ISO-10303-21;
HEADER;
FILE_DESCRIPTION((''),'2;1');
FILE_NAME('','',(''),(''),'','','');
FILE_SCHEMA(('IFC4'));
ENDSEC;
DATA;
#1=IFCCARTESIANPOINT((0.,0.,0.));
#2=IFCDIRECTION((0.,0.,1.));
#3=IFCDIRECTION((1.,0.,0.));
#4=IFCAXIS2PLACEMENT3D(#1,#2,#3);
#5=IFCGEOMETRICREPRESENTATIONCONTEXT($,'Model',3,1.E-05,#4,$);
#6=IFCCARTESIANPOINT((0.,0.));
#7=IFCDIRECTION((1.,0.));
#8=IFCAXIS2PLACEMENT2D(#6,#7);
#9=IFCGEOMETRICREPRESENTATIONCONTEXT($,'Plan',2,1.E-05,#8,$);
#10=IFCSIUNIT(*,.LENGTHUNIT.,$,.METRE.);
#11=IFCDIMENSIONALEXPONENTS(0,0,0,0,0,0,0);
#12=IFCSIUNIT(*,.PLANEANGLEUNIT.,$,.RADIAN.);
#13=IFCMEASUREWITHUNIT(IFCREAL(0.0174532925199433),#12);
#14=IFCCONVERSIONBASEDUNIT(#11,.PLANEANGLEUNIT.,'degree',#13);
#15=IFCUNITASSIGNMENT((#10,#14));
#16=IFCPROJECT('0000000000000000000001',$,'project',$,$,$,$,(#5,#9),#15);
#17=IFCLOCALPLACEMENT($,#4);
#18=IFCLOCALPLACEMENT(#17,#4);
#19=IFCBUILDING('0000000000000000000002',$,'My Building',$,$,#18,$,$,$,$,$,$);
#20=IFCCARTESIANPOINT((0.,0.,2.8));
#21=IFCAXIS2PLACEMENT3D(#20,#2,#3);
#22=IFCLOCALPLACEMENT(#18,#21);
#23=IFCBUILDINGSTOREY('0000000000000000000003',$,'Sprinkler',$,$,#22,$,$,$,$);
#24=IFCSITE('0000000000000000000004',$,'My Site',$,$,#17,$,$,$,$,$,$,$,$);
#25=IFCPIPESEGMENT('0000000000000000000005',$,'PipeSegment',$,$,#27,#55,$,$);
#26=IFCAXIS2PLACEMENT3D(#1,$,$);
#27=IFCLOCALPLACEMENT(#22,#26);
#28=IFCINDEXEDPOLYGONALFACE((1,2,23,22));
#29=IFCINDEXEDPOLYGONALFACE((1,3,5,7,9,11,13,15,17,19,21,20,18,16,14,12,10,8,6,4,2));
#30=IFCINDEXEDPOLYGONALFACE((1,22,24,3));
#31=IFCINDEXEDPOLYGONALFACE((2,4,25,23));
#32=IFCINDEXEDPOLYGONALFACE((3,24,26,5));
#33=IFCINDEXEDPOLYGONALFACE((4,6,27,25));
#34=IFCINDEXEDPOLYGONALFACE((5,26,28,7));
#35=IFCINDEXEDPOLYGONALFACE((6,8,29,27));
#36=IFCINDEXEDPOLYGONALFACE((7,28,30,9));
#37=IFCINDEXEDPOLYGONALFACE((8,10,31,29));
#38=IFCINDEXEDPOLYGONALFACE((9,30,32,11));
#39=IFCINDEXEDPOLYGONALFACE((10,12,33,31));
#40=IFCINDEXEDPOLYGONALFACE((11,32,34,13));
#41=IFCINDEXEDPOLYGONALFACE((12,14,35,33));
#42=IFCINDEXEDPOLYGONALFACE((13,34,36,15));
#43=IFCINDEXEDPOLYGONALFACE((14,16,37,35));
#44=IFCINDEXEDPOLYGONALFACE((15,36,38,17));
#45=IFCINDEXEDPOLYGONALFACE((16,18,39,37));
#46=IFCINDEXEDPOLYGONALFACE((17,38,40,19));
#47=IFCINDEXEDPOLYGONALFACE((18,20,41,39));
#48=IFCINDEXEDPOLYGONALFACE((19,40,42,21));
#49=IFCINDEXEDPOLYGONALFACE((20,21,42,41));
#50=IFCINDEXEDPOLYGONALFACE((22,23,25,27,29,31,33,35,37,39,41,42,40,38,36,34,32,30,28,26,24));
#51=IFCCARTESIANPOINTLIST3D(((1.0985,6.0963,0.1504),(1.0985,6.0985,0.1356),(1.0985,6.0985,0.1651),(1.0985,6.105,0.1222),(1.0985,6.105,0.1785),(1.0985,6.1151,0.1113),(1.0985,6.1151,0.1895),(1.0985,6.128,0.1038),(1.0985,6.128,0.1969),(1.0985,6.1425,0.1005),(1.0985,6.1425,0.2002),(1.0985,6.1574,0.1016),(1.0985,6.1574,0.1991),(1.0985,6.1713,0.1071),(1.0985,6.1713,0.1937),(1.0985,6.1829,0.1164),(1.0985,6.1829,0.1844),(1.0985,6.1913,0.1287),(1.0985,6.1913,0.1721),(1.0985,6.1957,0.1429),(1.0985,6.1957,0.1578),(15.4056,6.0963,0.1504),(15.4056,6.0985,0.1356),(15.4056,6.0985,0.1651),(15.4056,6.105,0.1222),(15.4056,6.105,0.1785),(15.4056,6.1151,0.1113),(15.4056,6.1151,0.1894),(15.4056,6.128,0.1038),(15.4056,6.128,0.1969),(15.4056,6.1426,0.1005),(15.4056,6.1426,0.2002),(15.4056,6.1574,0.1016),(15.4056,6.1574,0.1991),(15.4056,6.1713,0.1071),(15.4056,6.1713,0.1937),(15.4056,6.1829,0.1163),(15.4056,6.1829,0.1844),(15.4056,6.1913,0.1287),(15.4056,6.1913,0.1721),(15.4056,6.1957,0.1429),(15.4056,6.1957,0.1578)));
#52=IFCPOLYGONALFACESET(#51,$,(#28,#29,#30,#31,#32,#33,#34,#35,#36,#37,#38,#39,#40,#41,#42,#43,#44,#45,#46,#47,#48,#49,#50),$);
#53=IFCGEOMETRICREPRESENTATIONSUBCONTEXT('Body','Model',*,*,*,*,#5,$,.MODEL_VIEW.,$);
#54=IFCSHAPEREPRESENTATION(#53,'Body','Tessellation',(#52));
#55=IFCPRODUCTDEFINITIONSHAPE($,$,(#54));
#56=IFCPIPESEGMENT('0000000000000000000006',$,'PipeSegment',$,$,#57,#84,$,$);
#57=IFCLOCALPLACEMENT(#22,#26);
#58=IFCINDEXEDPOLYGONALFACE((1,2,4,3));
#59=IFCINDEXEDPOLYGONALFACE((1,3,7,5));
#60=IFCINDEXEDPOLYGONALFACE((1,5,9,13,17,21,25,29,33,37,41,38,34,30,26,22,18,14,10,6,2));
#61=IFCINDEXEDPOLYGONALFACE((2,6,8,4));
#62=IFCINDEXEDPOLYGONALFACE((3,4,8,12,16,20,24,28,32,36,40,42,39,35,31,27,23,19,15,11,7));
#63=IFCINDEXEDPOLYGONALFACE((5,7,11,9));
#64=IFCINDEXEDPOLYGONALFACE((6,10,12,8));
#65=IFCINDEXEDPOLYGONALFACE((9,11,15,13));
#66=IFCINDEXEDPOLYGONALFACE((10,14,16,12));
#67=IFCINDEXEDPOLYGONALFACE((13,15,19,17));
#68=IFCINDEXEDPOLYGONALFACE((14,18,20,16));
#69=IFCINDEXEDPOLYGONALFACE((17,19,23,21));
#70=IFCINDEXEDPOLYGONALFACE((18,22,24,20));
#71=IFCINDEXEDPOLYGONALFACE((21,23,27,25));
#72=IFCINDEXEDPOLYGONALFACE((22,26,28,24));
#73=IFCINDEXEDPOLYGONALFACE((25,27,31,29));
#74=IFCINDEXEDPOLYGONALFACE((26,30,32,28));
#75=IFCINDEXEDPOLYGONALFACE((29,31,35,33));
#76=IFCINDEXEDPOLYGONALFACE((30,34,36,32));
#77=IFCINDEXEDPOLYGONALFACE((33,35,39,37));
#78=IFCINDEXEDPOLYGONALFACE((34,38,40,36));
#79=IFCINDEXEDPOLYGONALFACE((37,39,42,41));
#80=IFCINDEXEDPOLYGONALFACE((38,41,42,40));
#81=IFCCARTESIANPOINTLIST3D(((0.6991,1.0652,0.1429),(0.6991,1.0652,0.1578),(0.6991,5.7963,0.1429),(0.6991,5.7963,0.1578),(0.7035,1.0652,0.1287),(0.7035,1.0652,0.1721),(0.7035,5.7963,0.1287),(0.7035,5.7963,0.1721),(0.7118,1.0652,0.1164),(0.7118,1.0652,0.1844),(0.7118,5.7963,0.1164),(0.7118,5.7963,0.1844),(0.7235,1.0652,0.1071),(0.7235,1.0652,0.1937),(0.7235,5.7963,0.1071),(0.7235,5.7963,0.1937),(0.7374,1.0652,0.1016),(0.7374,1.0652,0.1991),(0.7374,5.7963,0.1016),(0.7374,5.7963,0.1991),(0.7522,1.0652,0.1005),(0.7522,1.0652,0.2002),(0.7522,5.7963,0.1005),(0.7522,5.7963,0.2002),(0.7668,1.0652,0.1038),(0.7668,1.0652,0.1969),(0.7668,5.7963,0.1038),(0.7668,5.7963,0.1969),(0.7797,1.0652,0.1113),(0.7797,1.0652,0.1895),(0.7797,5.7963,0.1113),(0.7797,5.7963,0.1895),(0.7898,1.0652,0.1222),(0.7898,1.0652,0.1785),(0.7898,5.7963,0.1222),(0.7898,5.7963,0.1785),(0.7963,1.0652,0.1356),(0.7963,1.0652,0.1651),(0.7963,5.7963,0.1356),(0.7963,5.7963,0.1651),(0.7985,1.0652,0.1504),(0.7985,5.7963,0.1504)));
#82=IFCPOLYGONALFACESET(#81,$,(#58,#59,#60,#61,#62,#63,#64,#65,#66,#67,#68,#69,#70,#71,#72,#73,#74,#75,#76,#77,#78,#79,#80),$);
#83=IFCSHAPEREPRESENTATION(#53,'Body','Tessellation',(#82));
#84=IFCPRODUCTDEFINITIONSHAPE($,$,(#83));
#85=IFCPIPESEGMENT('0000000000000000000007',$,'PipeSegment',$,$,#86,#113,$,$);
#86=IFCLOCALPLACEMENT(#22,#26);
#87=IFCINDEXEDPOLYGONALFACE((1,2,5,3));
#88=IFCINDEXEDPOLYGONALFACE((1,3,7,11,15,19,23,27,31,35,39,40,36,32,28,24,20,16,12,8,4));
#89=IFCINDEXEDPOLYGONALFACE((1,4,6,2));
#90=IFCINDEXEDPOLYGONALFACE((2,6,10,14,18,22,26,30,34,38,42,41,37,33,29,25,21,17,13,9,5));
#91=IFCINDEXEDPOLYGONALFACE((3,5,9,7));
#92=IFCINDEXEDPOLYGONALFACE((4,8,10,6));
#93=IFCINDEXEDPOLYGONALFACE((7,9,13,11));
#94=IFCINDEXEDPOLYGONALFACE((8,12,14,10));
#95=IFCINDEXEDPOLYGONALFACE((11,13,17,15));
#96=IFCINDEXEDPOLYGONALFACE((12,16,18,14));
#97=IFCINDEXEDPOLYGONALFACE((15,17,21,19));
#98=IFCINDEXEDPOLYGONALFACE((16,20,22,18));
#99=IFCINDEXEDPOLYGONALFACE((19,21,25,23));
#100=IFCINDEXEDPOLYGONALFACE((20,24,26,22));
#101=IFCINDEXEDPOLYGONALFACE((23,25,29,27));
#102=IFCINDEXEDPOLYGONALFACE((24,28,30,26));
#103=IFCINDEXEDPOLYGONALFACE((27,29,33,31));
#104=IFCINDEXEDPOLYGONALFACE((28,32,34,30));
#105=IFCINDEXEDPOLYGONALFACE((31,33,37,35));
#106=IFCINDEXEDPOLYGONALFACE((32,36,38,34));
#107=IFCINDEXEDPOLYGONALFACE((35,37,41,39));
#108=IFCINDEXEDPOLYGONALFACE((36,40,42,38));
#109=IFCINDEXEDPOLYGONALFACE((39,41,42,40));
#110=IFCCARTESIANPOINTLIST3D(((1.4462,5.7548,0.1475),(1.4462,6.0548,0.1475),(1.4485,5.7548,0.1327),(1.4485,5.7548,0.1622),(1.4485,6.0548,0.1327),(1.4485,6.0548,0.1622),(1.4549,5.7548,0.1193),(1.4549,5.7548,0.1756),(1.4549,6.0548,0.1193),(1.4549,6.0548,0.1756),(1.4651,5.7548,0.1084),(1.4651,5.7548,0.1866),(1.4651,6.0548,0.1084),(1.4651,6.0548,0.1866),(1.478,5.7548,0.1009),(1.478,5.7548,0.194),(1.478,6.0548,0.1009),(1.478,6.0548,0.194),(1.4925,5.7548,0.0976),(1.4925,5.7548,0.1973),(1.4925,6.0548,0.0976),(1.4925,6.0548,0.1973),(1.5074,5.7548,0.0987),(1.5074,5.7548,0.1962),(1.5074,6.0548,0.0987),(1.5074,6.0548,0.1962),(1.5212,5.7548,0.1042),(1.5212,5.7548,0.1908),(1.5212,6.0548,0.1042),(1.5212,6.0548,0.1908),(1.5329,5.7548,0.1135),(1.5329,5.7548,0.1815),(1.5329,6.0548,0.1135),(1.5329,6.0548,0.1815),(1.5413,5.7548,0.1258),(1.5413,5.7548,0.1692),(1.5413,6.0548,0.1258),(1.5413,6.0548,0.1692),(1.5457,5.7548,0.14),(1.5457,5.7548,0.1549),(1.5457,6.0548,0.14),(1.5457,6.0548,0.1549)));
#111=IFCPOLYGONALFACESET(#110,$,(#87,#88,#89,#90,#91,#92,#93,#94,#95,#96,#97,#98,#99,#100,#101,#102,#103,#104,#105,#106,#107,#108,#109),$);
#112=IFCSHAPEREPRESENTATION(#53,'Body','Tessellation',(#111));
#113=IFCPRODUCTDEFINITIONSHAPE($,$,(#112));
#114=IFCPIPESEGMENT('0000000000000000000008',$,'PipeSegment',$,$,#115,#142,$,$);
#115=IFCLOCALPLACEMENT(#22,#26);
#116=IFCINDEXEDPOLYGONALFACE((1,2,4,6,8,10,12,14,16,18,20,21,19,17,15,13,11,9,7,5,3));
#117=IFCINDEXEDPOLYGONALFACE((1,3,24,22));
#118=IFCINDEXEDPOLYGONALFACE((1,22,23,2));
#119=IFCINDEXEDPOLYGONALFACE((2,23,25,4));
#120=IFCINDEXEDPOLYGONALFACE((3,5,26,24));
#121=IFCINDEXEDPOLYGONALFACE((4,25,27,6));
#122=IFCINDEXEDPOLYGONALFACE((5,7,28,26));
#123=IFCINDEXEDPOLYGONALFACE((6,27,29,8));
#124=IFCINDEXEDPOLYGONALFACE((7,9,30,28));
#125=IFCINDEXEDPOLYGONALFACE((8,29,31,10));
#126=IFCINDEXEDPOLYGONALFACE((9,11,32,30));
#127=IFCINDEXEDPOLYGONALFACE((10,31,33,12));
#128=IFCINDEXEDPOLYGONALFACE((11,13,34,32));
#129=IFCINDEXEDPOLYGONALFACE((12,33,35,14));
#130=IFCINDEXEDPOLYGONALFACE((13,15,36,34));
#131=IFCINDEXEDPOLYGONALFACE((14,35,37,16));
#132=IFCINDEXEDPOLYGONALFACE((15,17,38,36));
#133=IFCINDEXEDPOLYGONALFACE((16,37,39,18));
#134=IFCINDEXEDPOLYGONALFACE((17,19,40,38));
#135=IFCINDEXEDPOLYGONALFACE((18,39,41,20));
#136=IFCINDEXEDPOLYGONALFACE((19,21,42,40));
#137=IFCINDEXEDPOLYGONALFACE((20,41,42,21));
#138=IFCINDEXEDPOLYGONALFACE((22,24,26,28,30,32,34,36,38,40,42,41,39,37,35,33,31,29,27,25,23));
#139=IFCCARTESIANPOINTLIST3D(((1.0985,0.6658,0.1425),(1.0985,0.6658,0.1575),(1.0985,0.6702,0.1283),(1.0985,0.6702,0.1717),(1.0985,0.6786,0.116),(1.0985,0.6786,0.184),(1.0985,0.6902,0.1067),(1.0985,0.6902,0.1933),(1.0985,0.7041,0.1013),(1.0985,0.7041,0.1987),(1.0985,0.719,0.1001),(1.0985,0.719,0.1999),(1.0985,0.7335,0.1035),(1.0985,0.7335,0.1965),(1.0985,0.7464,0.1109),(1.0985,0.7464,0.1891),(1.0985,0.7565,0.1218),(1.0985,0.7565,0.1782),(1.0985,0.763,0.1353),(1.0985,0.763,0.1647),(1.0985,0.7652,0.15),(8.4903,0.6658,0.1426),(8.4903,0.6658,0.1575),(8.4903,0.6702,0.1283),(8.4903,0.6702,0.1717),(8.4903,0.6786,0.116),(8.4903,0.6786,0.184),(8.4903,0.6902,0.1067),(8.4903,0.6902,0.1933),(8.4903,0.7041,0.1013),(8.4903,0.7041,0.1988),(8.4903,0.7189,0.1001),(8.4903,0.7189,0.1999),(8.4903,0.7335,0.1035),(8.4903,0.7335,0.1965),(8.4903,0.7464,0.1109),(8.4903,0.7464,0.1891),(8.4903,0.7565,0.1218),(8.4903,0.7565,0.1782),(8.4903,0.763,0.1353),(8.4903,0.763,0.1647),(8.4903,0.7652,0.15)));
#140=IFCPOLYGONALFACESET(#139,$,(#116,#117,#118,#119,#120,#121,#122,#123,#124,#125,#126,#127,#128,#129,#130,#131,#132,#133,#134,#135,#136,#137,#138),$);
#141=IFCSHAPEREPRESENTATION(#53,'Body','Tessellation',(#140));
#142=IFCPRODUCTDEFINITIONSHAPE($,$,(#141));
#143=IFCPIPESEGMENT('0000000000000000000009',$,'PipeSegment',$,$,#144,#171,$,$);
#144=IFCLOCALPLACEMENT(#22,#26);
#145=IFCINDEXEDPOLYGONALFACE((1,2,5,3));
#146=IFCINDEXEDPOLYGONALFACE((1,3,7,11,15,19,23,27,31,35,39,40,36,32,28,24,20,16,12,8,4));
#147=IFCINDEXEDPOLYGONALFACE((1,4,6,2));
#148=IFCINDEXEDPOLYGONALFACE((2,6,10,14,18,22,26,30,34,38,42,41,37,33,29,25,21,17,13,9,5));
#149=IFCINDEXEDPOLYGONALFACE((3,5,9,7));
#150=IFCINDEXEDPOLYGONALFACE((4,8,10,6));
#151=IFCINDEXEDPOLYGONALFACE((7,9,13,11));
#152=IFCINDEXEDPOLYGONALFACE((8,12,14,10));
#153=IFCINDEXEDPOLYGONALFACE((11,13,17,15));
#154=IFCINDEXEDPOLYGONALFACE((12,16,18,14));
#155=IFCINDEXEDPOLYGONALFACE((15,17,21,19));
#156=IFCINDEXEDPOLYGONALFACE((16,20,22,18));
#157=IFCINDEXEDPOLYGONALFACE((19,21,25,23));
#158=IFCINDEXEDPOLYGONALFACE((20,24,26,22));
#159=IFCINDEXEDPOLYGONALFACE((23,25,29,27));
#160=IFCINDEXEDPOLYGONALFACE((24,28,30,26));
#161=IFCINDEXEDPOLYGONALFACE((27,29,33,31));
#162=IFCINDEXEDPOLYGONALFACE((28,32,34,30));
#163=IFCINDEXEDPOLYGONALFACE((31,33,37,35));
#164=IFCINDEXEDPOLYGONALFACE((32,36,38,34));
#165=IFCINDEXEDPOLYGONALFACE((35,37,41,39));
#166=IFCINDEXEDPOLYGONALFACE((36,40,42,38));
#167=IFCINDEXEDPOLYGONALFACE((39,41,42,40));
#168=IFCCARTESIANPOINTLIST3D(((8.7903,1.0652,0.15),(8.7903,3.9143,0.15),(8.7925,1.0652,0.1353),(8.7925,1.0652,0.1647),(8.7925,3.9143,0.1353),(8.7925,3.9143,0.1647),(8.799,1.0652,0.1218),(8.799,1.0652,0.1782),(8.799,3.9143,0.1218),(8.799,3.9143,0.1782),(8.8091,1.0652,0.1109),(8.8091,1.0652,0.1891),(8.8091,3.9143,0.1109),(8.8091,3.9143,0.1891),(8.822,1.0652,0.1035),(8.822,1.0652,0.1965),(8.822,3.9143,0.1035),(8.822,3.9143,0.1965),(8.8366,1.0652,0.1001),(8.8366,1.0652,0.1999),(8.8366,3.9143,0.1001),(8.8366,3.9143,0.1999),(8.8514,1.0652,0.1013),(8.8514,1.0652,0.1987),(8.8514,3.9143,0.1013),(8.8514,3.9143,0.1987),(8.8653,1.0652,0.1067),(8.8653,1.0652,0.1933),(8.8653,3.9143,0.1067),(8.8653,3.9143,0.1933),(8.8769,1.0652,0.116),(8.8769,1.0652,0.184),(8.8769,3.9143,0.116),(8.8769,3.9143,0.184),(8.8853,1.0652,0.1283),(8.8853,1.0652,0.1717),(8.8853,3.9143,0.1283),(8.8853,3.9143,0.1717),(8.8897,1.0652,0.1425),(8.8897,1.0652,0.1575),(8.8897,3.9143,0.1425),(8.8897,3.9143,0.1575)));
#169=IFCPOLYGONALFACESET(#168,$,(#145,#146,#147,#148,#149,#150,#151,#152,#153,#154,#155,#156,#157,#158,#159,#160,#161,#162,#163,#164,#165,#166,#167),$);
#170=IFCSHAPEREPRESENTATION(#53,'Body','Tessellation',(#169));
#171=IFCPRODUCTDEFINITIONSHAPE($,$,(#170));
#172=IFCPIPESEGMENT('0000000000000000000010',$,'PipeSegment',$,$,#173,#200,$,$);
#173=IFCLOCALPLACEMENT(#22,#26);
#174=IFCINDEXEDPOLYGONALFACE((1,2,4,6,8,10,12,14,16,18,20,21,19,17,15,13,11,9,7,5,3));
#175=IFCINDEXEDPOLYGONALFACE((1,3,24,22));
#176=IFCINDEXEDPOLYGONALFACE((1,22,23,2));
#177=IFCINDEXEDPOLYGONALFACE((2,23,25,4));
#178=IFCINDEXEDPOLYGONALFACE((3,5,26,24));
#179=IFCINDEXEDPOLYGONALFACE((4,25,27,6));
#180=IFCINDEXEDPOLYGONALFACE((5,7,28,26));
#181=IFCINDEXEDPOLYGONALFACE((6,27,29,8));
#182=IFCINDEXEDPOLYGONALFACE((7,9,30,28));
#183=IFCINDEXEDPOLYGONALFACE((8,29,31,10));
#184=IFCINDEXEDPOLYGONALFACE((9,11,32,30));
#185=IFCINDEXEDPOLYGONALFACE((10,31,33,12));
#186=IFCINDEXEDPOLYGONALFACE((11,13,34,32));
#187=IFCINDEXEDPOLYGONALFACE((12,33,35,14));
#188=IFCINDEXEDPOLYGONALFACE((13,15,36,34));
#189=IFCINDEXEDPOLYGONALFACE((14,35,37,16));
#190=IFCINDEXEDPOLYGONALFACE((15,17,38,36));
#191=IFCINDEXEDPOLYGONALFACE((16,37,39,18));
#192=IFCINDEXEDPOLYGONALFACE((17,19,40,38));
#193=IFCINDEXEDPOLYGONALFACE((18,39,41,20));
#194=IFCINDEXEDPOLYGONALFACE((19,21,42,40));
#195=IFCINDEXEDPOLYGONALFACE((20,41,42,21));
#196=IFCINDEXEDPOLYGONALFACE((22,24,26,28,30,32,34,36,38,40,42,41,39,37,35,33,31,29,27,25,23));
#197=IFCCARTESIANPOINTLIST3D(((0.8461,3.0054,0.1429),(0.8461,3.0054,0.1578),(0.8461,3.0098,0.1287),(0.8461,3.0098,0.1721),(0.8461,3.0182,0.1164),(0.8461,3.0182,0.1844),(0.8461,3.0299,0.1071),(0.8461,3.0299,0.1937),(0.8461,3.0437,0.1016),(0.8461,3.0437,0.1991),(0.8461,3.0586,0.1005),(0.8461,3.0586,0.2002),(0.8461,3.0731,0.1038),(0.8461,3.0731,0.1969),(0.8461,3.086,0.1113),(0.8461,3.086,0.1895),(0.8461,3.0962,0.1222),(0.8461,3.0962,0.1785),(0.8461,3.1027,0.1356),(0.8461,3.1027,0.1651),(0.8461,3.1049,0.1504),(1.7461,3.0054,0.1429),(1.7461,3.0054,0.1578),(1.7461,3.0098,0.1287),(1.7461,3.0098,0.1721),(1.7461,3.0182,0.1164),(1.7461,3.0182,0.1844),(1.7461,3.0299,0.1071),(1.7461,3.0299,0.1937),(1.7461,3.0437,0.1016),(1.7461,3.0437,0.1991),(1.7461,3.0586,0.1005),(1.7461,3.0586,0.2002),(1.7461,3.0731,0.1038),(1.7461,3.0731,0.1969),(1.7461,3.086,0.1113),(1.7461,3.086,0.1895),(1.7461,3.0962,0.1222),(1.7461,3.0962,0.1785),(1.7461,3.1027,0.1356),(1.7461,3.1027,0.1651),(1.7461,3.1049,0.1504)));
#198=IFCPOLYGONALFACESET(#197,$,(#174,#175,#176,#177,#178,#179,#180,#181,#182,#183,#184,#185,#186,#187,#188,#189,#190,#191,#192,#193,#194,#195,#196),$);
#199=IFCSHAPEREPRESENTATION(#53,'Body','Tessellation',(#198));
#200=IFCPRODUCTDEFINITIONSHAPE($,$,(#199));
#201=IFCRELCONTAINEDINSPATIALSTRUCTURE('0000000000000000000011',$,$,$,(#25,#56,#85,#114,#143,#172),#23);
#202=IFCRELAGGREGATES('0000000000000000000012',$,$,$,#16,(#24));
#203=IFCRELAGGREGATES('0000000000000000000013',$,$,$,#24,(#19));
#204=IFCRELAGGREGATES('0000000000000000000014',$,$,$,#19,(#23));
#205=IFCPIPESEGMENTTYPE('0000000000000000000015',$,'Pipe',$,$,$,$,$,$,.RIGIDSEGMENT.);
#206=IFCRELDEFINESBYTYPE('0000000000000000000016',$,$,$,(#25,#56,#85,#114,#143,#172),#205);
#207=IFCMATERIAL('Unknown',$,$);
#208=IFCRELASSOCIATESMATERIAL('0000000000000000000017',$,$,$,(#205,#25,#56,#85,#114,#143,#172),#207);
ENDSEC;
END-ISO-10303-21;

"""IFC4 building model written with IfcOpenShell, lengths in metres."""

from ifc_helpers import new_model, entity, si_unit, converted_unit, frame, origin_with_axes, origin_2d_with_axis, place, context, subcontext, project, spatial, circle, extrude, material, material_profile, profile_set, profile_usage, type_object, element, save


model = new_model("IFC4")

# Units and contexts
model_context = context("Model", 3, precision=1e-05, world=origin_with_axes())
plan_context = context("Plan", 2, precision=1e-05, world=origin_2d_with_axis())
body_context = subcontext(model_context, "Body", "Model", "MODEL_VIEW")
ifc_project = project(units=[si_unit("LENGTHUNIT", "METRE"), converted_unit("PLANEANGLEUNIT", "degree", entity("IfcReal", 0.0174532925199433), si_unit("PLANEANGLEUNIT", "RADIAN"), dimensions=[0, 0, 0, 0, 0, 0, 0])], contexts=[model_context, plan_context])

# Site, building, storey
site_placement = place(None, origin_with_axes())
site = spatial("IfcSite", under=ifc_project, at=site_placement, Name="My Site")
building_placement = place(site_placement, origin_with_axes())
building = spatial("IfcBuilding", under=site, at=building_placement, Name="My Building")
storey_placement = place(building_placement, frame((0.0, 0.0, 2.8), z_axis=(0.0, 0.0, 1.0), x_axis=(1.0, 0.0, 0.0)))
storey = spatial("IfcBuildingStorey", under=building, at=storey_placement, Name="Sprinkler")

# Pipe segments
ifc_material = material(Name="Unknown")
ifc_material_profile_1 = material_profile(ifc_material, circle(Radius=0.05))
ifc_profile_set_1 = profile_set([ifc_material_profile_1])
ifc_profile_usage_1 = profile_usage(ifc_profile_set_1, cardinal=5)
pipe_segment_type = type_object("IfcPipeSegmentType", Name="Pipe", PredefinedType="RIGIDSEGMENT", material=ifc_profile_set_1)
pipe_segment_1_placement = place(storey_placement, frame((15.4056, 6.1463, 0.1504), z_axis=(-1.0, -0.000001, 0.0), x_axis=(0.000001, -1.0, 0.0)))
element("IfcPipeSegment", 1, at=pipe_segment_1_placement, inside=storey, type_object=pipe_segment_type, material=ifc_profile_usage_1, Name="PipeSegment", context=body_context, shape_type="SweptSolid", body=[
    extrude(circle(Radius=0.05), origin_with_axes(), (0.0, 0.0, 1.0), 14.3071),
])
ifc_profile_usage_2 = profile_usage(ifc_profile_set_1, cardinal=5)
pipe_segment_2_placement = place(storey_placement, frame((0.7485, 5.7963, 0.1504), z_axis=(0.0, -1.0, 0.0), x_axis=(1.0, 0.0, 0.0)))
element("IfcPipeSegment", 2, at=pipe_segment_2_placement, inside=storey, type_object=pipe_segment_type, material=ifc_profile_usage_2, Name="PipeSegment", context=body_context, shape_type="SweptSolid", body=[
    extrude(circle(Radius=0.05), origin_with_axes(), (0.0, 0.0, 1.0), 4.7311),
])
ifc_profile_usage_3 = profile_usage(ifc_profile_set_1, cardinal=5)
pipe_segment_3_placement = place(storey_placement, frame((1.4962, 5.7548, 0.1475), z_axis=(0.0, 1.0, -0.000008), x_axis=(-1.0, 0.0, 0.0)))
element("IfcPipeSegment", 3, at=pipe_segment_3_placement, inside=storey, type_object=pipe_segment_type, material=ifc_profile_usage_3, Name="PipeSegment", context=body_context, shape_type="SweptSolid", body=[
    extrude(circle(Radius=0.05), origin_with_axes(), (0.0, 0.0, 1.0), 0.3),
])
ifc_profile_usage_4 = profile_usage(ifc_profile_set_1, cardinal=8)
pipe_segment_4_placement = place(storey_placement, frame((1.0985, 0.7152, 0.2), z_axis=(1.0, -0.000001, 0.000001), x_axis=(0.000001, 1.0, 0.0)))
element("IfcPipeSegment", 4, at=pipe_segment_4_placement, inside=storey, type_object=pipe_segment_type, material=ifc_profile_usage_4, Name="PipeSegment", context=body_context, shape_type="SweptSolid", body=[
    extrude(circle(Radius=0.05), frame((0.0, -0.05, 0.0), z_axis=(0.0, 0.0, 1.0), x_axis=(1.0, 0.0, 0.0)), (0.0, 0.0, 1.0), 7.3918),
])
ifc_profile_usage_5 = profile_usage(ifc_profile_set_1, cardinal=8)
pipe_segment_5_placement = place(storey_placement, frame((8.8403, 1.0652, 0.2), z_axis=(0.0, 1.0, 0.0), x_axis=(-1.0, 0.0, 0.0)))
element("IfcPipeSegment", 5, at=pipe_segment_5_placement, inside=storey, type_object=pipe_segment_type, material=ifc_profile_usage_5, Name="PipeSegment", context=body_context, shape_type="SweptSolid", body=[
    extrude(circle(Radius=0.05), frame((0.0, -0.05, 0.0), z_axis=(0.0, 0.0, 1.0), x_axis=(1.0, 0.0, 0.0)), (0.0, 0.0, 1.0), 2.8491),
])
ifc_profile_usage_6 = profile_usage(ifc_profile_set_1, cardinal=8)
pipe_segment_6_placement = place(storey_placement, frame((0.8461, 3.0549, 0.2004), z_axis=(1.0, 0.0, 0.0), x_axis=(0.0, 1.0, 0.0)))
element("IfcPipeSegment", 6, at=pipe_segment_6_placement, inside=storey, type_object=pipe_segment_type, material=ifc_profile_usage_6, Name="PipeSegment", context=body_context, shape_type="SweptSolid", body=[
    extrude(circle(Radius=0.05), frame((0.0, -0.05, 0.0), z_axis=(0.0, 0.0, 1.0), x_axis=(1.0, 0.0, 0.0)), (0.0, 0.0, 1.0), 0.9),
])

save(model, "model.ifc")
